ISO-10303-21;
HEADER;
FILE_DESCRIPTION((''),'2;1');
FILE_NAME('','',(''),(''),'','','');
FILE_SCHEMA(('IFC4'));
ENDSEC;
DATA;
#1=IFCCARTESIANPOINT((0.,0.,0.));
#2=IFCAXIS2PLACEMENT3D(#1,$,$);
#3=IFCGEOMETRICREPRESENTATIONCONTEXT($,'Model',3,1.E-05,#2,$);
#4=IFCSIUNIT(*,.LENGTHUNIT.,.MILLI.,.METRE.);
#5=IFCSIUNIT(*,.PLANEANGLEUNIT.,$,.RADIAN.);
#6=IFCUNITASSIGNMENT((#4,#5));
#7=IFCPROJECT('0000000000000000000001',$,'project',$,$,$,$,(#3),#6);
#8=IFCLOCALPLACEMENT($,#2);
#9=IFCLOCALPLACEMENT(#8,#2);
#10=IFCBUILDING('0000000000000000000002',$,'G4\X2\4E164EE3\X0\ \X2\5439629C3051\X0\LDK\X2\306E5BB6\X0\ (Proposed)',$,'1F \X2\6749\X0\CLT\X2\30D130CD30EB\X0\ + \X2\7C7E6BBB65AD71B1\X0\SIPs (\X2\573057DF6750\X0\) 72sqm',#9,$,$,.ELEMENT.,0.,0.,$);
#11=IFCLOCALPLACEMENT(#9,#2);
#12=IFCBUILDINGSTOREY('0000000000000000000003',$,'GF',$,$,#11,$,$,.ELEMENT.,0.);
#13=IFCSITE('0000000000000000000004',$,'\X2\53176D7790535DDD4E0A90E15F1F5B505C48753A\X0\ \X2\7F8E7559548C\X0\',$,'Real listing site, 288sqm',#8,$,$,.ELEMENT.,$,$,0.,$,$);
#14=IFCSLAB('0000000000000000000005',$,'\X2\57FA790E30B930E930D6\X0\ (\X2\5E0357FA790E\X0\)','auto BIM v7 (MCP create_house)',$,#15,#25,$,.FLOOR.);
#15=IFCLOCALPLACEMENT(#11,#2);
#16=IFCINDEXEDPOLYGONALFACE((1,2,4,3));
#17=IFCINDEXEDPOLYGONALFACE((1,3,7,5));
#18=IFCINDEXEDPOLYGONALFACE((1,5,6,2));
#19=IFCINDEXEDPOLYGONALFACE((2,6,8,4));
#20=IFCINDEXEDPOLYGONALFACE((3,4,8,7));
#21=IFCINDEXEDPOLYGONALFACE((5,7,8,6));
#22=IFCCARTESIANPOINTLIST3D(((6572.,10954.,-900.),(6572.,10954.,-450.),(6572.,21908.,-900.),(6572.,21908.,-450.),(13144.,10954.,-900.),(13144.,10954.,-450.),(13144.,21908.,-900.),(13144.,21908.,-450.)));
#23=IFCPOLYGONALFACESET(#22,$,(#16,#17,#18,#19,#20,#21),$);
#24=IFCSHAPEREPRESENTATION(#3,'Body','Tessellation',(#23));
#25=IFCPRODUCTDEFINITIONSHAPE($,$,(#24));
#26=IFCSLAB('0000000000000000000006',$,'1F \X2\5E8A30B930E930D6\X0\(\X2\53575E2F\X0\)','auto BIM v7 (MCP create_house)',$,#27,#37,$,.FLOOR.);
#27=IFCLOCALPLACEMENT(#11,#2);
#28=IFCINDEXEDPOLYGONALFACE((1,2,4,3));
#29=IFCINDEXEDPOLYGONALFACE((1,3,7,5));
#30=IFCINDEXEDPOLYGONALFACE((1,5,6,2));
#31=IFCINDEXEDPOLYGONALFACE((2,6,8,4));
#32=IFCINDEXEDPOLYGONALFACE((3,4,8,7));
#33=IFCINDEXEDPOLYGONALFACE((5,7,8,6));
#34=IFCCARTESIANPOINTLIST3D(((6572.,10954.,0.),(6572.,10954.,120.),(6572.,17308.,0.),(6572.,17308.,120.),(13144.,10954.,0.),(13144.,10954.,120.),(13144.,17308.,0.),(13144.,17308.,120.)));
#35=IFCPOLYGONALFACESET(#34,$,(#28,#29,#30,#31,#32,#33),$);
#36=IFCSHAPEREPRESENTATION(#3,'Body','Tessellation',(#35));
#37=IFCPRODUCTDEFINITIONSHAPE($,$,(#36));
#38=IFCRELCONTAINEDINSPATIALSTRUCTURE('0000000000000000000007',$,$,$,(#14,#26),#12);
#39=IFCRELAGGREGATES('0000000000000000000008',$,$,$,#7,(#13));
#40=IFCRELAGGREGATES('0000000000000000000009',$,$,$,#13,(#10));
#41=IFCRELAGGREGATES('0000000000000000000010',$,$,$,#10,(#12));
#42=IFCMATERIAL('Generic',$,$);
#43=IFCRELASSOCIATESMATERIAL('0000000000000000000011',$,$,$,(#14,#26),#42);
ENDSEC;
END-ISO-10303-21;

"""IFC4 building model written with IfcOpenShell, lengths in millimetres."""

from ifc_helpers import new_model, si_unit, frame, frame_2d, origin, place, context, project, spatial, rectangle, extrude, material, element, save


model = new_model("IFC4")

# Units and contexts
model_context = context("Model", 3, precision=1e-05, world=origin())
ifc_project = project(units=[si_unit("LENGTHUNIT", "METRE", prefix="MILLI"), si_unit("PLANEANGLEUNIT", "RADIAN")], contexts=[model_context])

# Site, building, storey
site_placement = place(None, origin())
site = spatial("IfcSite", under=ifc_project, at=site_placement, Name="北海道川上郡弟子屈町 美留和", ObjectType="Real listing site, 288sqm", CompositionType="ELEMENT", RefElevation=0.0)
building_placement = place(site_placement, origin())
building = spatial("IfcBuilding", under=site, at=building_placement, Name="G4世代 吹抜けLDKの家 (Proposed)", ObjectType="1F 杉CLTパネル + 籾殻断熱SIPs (地域材) 72sqm", CompositionType="ELEMENT", ElevationOfRefHeight=0.0, ElevationOfTerrain=0.0)
storey_placement = place(building_placement, origin())
storey = spatial("IfcBuildingStorey", under=building, at=storey_placement, Name="GF", CompositionType="ELEMENT", Elevation=0.0)

# Slabs
ifc_material = material(Name="Generic")
slab_1_placement = place(storey_placement, frame((3286.0, 5477.0, -450.0)))
element("IfcSlab", 1, at=slab_1_placement, inside=storey, material=ifc_material, Name="基礎スラブ (布基礎)", Description="auto BIM v7 (MCP create_house)", PredefinedType="FLOOR", context=model_context, shape_type="SweptSolid", body=[
    extrude(rectangle(XDim=6572.0, YDim=10954.0, at=frame_2d((3286.0, 5477.0))), frame((3286.0, 5477.0, -450.0)), (0.0, 0.0, 1.0), 450.0),
])
slab_2_placement = place(storey_placement, frame((3286.0, 5477.0, 0.0)))
element("IfcSlab", 2, at=slab_2_placement, inside=storey, material=ifc_material, Name="1F 床スラブ(南帯)", Description="auto BIM v7 (MCP create_house)", PredefinedType="FLOOR", context=model_context, shape_type="SweptSolid", body=[
    extrude(rectangle(XDim=6572.0, YDim=6354.0, at=frame_2d((3286.0, 3177.0))), frame((3286.0, 5477.0, 0.0)), (0.0, 0.0, 1.0), 120.0),
])

save(model, "model.ifc")
